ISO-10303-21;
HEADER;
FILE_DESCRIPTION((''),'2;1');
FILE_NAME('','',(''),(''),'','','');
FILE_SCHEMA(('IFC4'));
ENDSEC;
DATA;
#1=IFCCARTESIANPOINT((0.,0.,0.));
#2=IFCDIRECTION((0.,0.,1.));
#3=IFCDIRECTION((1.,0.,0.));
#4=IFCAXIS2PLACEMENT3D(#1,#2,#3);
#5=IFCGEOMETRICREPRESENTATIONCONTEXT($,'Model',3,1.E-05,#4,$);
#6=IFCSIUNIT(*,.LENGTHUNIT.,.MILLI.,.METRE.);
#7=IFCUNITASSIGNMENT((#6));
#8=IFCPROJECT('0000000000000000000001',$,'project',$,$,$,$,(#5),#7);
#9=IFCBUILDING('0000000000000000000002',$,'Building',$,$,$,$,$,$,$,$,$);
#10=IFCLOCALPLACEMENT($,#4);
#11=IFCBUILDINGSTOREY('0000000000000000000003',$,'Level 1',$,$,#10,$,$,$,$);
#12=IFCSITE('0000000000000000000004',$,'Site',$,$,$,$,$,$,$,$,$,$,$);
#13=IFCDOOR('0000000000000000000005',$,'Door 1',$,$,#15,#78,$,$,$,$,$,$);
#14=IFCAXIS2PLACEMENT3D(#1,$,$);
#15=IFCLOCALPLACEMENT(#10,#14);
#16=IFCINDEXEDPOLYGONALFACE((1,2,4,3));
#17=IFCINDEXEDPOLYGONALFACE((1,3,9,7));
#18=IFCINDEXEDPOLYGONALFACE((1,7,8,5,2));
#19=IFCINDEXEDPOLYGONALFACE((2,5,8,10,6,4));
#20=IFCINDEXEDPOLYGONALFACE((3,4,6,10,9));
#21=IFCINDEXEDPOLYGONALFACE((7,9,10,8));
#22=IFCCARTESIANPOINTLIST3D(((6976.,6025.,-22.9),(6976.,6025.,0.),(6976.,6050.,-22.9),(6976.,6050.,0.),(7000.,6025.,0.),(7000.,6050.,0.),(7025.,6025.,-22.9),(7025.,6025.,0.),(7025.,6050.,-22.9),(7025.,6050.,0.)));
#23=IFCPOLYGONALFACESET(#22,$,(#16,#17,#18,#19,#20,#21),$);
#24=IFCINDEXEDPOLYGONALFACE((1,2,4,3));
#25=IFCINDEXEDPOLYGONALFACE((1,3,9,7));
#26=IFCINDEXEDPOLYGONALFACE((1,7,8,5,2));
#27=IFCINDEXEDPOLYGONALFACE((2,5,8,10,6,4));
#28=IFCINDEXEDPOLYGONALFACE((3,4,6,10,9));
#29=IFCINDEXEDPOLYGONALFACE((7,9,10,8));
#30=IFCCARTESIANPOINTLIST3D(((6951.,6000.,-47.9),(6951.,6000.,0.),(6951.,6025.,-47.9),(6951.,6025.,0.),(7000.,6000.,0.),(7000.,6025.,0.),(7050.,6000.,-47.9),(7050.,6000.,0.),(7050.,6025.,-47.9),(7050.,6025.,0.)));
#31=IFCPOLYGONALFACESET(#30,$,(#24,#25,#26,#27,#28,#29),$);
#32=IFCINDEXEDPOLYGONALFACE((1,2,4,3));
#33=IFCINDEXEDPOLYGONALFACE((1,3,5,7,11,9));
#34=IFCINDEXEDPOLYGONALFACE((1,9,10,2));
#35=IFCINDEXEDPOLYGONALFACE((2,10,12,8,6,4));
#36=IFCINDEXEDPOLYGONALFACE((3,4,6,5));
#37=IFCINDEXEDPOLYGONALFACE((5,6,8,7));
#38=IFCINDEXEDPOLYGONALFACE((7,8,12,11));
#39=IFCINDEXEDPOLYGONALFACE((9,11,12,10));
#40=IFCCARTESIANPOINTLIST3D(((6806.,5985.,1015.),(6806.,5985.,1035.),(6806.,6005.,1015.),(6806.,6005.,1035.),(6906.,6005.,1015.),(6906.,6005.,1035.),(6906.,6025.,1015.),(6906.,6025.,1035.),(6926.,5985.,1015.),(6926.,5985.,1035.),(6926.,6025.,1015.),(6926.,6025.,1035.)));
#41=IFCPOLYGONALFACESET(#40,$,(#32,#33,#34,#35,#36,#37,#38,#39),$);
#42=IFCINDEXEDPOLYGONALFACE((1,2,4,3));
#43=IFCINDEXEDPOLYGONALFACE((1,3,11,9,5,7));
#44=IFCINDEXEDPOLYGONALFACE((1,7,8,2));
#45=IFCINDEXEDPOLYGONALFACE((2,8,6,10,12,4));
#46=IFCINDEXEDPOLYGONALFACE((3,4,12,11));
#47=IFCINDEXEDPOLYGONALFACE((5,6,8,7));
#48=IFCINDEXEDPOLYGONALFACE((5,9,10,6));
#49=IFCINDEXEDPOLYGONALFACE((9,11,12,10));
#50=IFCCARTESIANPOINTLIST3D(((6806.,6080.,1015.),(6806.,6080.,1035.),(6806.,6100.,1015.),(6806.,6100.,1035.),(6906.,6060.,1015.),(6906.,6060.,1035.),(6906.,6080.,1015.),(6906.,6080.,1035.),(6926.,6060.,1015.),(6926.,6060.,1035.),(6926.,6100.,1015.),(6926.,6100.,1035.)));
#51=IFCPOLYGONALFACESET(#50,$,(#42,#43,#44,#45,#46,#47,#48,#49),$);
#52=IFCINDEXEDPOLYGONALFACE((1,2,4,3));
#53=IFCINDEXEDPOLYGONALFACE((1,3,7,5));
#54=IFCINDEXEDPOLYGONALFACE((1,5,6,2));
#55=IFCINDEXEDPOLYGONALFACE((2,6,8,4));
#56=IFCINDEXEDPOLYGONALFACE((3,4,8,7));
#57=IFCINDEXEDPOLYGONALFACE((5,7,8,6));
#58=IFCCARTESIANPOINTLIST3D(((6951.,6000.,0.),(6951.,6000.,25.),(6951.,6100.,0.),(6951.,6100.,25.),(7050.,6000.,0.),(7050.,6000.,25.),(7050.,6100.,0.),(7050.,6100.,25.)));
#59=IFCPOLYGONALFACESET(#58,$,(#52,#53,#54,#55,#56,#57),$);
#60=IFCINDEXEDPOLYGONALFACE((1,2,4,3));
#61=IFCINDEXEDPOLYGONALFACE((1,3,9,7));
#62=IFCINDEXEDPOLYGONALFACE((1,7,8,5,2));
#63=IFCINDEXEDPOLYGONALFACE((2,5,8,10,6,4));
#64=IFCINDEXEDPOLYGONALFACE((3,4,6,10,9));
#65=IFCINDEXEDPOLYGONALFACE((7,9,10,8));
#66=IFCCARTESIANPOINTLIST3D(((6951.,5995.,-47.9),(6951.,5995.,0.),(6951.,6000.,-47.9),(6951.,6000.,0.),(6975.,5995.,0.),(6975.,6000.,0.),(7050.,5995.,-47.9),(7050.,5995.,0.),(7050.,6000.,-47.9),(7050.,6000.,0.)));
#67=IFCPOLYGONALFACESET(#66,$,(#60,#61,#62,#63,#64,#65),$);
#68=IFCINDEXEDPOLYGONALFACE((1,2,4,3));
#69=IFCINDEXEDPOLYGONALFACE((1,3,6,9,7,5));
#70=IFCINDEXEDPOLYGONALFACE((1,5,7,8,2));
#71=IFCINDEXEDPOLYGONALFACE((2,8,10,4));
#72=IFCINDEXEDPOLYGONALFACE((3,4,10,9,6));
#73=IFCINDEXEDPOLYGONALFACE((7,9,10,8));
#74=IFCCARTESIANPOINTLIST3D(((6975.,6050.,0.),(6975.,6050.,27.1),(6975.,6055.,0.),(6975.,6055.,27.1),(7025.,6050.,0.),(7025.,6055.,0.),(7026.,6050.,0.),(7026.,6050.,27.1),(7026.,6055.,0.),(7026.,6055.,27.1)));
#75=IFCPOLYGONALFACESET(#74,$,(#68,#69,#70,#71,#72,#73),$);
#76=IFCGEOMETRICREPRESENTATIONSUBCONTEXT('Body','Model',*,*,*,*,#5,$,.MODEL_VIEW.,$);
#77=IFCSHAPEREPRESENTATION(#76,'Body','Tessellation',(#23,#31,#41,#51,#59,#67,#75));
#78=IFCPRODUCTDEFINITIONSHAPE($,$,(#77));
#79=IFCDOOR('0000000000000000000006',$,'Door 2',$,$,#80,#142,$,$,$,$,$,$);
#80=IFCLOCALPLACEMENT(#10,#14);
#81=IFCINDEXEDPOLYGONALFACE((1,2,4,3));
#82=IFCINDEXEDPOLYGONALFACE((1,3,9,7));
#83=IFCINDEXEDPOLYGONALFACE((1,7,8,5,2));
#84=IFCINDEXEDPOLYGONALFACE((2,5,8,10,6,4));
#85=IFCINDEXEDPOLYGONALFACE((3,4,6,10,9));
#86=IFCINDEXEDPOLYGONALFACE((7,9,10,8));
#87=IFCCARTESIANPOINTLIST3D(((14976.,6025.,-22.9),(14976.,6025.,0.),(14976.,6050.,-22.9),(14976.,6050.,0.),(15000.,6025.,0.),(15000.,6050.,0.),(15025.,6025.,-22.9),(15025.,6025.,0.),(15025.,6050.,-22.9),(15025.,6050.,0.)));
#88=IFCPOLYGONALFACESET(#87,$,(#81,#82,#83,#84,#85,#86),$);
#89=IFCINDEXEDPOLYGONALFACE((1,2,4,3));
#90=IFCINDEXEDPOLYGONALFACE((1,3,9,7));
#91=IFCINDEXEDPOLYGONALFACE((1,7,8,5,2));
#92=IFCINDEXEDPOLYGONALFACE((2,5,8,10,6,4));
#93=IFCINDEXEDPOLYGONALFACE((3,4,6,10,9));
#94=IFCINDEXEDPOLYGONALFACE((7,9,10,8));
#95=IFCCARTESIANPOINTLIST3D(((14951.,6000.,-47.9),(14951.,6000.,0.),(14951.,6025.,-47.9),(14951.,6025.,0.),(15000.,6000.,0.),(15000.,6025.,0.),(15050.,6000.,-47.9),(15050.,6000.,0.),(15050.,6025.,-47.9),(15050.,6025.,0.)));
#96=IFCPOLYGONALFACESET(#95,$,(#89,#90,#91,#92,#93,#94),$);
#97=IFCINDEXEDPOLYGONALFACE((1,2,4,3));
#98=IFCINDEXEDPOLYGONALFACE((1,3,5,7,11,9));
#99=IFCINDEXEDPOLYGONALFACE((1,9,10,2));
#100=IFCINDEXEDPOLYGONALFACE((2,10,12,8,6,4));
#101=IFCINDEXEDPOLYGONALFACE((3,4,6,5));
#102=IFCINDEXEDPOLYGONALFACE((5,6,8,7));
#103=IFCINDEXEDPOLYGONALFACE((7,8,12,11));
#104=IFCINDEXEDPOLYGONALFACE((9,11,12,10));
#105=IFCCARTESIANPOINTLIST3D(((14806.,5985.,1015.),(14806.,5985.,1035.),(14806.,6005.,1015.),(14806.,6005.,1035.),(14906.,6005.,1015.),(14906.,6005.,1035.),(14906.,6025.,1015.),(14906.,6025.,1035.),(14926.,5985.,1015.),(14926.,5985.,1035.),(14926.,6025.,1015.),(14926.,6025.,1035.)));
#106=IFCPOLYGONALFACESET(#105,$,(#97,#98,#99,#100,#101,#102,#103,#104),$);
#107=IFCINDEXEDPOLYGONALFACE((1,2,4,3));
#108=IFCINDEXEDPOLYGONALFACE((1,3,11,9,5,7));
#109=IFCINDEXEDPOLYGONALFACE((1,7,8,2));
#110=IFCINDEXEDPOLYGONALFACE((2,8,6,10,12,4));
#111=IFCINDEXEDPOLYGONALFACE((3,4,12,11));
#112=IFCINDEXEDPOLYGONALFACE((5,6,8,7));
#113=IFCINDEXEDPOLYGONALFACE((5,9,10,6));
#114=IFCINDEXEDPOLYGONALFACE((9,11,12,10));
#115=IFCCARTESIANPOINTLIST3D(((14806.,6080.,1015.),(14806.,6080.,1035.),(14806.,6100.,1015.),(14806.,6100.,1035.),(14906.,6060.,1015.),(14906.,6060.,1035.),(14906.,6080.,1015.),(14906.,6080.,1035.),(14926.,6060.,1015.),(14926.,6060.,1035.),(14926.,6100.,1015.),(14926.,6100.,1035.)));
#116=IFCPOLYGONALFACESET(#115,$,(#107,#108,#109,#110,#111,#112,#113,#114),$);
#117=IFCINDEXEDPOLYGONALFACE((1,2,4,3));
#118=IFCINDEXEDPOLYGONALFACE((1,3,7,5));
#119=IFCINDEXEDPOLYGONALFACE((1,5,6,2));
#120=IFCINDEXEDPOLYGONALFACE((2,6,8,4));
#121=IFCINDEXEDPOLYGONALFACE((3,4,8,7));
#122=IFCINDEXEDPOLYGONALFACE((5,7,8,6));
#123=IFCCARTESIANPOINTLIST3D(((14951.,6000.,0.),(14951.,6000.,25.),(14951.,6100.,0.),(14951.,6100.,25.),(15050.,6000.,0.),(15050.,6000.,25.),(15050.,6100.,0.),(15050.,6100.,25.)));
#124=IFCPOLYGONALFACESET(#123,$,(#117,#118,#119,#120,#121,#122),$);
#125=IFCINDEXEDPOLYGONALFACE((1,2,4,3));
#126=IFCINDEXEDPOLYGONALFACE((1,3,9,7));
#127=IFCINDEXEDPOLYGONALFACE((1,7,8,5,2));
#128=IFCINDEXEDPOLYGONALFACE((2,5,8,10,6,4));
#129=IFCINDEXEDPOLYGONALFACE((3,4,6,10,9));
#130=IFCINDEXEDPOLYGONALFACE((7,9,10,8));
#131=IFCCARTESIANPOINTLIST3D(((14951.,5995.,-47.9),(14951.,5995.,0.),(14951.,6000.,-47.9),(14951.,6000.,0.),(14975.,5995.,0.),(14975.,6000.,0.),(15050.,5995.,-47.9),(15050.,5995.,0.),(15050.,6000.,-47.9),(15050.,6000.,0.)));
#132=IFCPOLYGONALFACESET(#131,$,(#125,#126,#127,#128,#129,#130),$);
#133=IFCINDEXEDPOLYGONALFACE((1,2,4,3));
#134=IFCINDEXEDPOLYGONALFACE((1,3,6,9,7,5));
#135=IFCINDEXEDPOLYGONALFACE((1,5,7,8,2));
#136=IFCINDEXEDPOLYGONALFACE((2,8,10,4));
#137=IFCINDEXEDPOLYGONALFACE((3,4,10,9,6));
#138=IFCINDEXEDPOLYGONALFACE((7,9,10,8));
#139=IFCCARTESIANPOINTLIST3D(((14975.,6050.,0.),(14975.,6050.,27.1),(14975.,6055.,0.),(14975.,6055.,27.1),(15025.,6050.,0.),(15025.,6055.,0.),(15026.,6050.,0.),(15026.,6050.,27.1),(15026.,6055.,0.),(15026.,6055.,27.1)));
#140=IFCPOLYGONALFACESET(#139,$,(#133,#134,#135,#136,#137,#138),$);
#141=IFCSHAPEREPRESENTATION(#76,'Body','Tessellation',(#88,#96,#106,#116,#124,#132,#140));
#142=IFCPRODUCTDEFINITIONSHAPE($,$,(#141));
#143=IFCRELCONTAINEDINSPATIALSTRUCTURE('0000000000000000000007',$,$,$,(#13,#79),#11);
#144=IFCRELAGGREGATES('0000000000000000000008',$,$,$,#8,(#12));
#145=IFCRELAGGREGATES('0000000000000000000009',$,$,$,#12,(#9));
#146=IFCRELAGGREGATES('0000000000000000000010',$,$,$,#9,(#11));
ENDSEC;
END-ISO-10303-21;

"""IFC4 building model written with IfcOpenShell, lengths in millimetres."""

from ifc_helpers import new_model, si_unit, frame, origin_with_axes, place, context, subcontext, project, spatial, line, indexed_curve, outline, extrude, element, save


model = new_model("IFC4")

# Units and contexts
model_context = context("Model", 3, precision=1e-05, world=origin_with_axes())
body_context = subcontext(model_context, "Body", "Model", "MODEL_VIEW")
ifc_project = project(units=[si_unit("LENGTHUNIT", "METRE", prefix="MILLI")], contexts=[model_context])

# Site, building, storey
site = spatial("IfcSite", under=ifc_project, Name="Site")
building = spatial("IfcBuilding", under=site, Name="Building")
storey_placement = place(None, origin_with_axes())
storey = spatial("IfcBuildingStorey", under=building, at=storey_placement, Name="Level 1")

# Doors
door_1_placement = place(storey_placement, frame((7000.0, 6000.0, 0.0), z_axis=(0.0, 0.0, 1.0), x_axis=(1.0, 0.0, 0.0)))
element("IfcDoor", 1, at=door_1_placement, inside=storey, Name="Door 1", context=body_context, shape_type="SweptSolid", body=[
    extrude(outline(indexed_curve([(0.0, 0.0), (0.0, 2.1), (1.0, 2.1), (1.0, 0.0), (-24.0, 0.0), (-24.0, -22.9), (25.0, -22.9), (25.0, 0.0)], segments=[line(1, 2, 3, 4, 5, 6, 7, 8, 1)])), frame((0.0, 25.0, 0.0), z_axis=(0.0, -1.0, 0.0), x_axis=(1.0, 0.0, 0.0)), (0.0, 0.0, -1.0), 25.0),
    extrude(outline(indexed_curve([(0.0, 0.0), (0.0, 2.1), (1.0, 2.1), (1.0, 0.0), (-49.0, 0.0), (-49.0, -47.9), (50.0, -47.9), (50.0, 0.0)], segments=[line(1, 2, 3, 4, 5, 6, 7, 8, 1)])), frame((0.0, 0.0, 0.0), z_axis=(0.0, -1.0, 0.0), x_axis=(1.0, 0.0, 0.0)), (0.0, 0.0, -1.0), 25.0),
    extrude(outline(indexed_curve([(0.0, 0.0), (-49.0, 0.0), (-49.0, 35.0), (0.0, 35.0)], segments=[line(1, 2, 3, 4, 1)])), frame((25.0, 25.0, 25.0), z_axis=(0.0, 0.0, 1.0), x_axis=(1.0, 0.0, 0.0)), (0.0, 0.0, 1.0), -47.9),
    extrude(outline(indexed_curve([(0.0, 0.0), (0.0, -40.0), (-120.0, -40.0), (-120.0, -20.0), (-20.0, -20.0), (-20.0, 0.0)], segments=[line(1, 2, 3, 4, 5, 6, 1)])), frame((-74.0, 25.0, 1015.0), z_axis=(0.0, 0.0, 1.0), x_axis=(1.0, 0.0, 0.0)), (0.0, 0.0, 1.0), 20.0),
    extrude(outline(indexed_curve([(0.0, 0.0), (0.0, 40.0), (-120.0, 40.0), (-120.0, 20.0), (-20.0, 20.0), (-20.0, 0.0)], segments=[line(1, 2, 3, 4, 5, 6, 1)])), frame((-74.0, 60.0, 1015.0), z_axis=(0.0, 0.0, 1.0), x_axis=(1.0, 0.0, 0.0)), (0.0, 0.0, 1.0), 20.0),
    extrude(outline(indexed_curve([(0.0, 0.0), (-99.0, 0.0), (-99.0, 100.0), (0.0, 100.0)], segments=[line(1, 2, 3, 4, 1)])), frame((50.0, 0.0, 0.0), z_axis=(0.0, 0.0, 1.0), x_axis=(1.0, 0.0, 0.0)), (0.0, 0.0, 1.0), 25.0),
    extrude(outline(indexed_curve([(0.0, 0.0), (0.0, 27.1), (51.0, 27.1), (51.0, 0.0), (-24.0, 0.0), (-24.0, -47.9), (75.0, -47.9), (75.0, 0.0)], segments=[line(1, 2, 3, 4, 5, 6, 7, 8, 1)])), frame((-25.0, -5.0, 0.0), z_axis=(0.0, -1.0, 0.0), x_axis=(1.0, 0.0, 0.0)), (0.0, 0.0, -1.0), 5.0),
    extrude(outline(indexed_curve([(0.0, 0.0), (0.0, 27.1), (51.0, 27.1), (51.0, 0.0), (1.0, 0.0), (1.0, -22.9), (50.0, -22.9), (50.0, 0.0)], segments=[line(1, 2, 3, 4, 5, 6, 7, 8, 1)])), frame((-25.0, 50.0, 0.0), z_axis=(0.0, -1.0, 0.0), x_axis=(1.0, 0.0, 0.0)), (0.0, 0.0, -1.0), 5.0),
])
door_2_placement = place(storey_placement, frame((15000.0, 6000.0, 0.0), z_axis=(0.0, 0.0, 1.0), x_axis=(1.0, 0.0, 0.0)))
element("IfcDoor", 2, at=door_2_placement, inside=storey, Name="Door 2", context=body_context, shape_type="SweptSolid", body=[
    extrude(outline(indexed_curve([(0.0, 0.0), (0.0, 2.1), (1.0, 2.1), (1.0, 0.0), (-24.0, 0.0), (-24.0, -22.9), (25.0, -22.9), (25.0, 0.0)], segments=[line(1, 2, 3, 4, 5, 6, 7, 8, 1)])), frame((0.0, 25.0, 0.0), z_axis=(0.0, -1.0, 0.0), x_axis=(1.0, 0.0, 0.0)), (0.0, 0.0, -1.0), 25.0),
    extrude(outline(indexed_curve([(0.0, 0.0), (0.0, 2.1), (1.0, 2.1), (1.0, 0.0), (-49.0, 0.0), (-49.0, -47.9), (50.0, -47.9), (50.0, 0.0)], segments=[line(1, 2, 3, 4, 5, 6, 7, 8, 1)])), frame((0.0, 0.0, 0.0), z_axis=(0.0, -1.0, 0.0), x_axis=(1.0, 0.0, 0.0)), (0.0, 0.0, -1.0), 25.0),
    extrude(outline(indexed_curve([(0.0, 0.0), (-49.0, 0.0), (-49.0, 35.0), (0.0, 35.0)], segments=[line(1, 2, 3, 4, 1)])), frame((25.0, 25.0, 25.0), z_axis=(0.0, 0.0, 1.0), x_axis=(1.0, 0.0, 0.0)), (0.0, 0.0, 1.0), -47.9),
    extrude(outline(indexed_curve([(0.0, 0.0), (0.0, -40.0), (-120.0, -40.0), (-120.0, -20.0), (-20.0, -20.0), (-20.0, 0.0)], segments=[line(1, 2, 3, 4, 5, 6, 1)])), frame((-74.0, 25.0, 1015.0), z_axis=(0.0, 0.0, 1.0), x_axis=(1.0, 0.0, 0.0)), (0.0, 0.0, 1.0), 20.0),
    extrude(outline(indexed_curve([(0.0, 0.0), (0.0, 40.0), (-120.0, 40.0), (-120.0, 20.0), (-20.0, 20.0), (-20.0, 0.0)], segments=[line(1, 2, 3, 4, 5, 6, 1)])), frame((-74.0, 60.0, 1015.0), z_axis=(0.0, 0.0, 1.0), x_axis=(1.0, 0.0, 0.0)), (0.0, 0.0, 1.0), 20.0),
    extrude(outline(indexed_curve([(0.0, 0.0), (-99.0, 0.0), (-99.0, 100.0), (0.0, 100.0)], segments=[line(1, 2, 3, 4, 1)])), frame((50.0, 0.0, 0.0), z_axis=(0.0, 0.0, 1.0), x_axis=(1.0, 0.0, 0.0)), (0.0, 0.0, 1.0), 25.0),
    extrude(outline(indexed_curve([(0.0, 0.0), (0.0, 27.1), (51.0, 27.1), (51.0, 0.0), (-24.0, 0.0), (-24.0, -47.9), (75.0, -47.9), (75.0, 0.0)], segments=[line(1, 2, 3, 4, 5, 6, 7, 8, 1)])), frame((-25.0, -5.0, 0.0), z_axis=(0.0, -1.0, 0.0), x_axis=(1.0, 0.0, 0.0)), (0.0, 0.0, -1.0), 5.0),
    extrude(outline(indexed_curve([(0.0, 0.0), (0.0, 27.1), (51.0, 27.1), (51.0, 0.0), (1.0, 0.0), (1.0, -22.9), (50.0, -22.9), (50.0, 0.0)], segments=[line(1, 2, 3, 4, 5, 6, 7, 8, 1)])), frame((-25.0, 50.0, 0.0), z_axis=(0.0, -1.0, 0.0), x_axis=(1.0, 0.0, 0.0)), (0.0, 0.0, -1.0), 5.0),
])

save(model, "model.ifc")
